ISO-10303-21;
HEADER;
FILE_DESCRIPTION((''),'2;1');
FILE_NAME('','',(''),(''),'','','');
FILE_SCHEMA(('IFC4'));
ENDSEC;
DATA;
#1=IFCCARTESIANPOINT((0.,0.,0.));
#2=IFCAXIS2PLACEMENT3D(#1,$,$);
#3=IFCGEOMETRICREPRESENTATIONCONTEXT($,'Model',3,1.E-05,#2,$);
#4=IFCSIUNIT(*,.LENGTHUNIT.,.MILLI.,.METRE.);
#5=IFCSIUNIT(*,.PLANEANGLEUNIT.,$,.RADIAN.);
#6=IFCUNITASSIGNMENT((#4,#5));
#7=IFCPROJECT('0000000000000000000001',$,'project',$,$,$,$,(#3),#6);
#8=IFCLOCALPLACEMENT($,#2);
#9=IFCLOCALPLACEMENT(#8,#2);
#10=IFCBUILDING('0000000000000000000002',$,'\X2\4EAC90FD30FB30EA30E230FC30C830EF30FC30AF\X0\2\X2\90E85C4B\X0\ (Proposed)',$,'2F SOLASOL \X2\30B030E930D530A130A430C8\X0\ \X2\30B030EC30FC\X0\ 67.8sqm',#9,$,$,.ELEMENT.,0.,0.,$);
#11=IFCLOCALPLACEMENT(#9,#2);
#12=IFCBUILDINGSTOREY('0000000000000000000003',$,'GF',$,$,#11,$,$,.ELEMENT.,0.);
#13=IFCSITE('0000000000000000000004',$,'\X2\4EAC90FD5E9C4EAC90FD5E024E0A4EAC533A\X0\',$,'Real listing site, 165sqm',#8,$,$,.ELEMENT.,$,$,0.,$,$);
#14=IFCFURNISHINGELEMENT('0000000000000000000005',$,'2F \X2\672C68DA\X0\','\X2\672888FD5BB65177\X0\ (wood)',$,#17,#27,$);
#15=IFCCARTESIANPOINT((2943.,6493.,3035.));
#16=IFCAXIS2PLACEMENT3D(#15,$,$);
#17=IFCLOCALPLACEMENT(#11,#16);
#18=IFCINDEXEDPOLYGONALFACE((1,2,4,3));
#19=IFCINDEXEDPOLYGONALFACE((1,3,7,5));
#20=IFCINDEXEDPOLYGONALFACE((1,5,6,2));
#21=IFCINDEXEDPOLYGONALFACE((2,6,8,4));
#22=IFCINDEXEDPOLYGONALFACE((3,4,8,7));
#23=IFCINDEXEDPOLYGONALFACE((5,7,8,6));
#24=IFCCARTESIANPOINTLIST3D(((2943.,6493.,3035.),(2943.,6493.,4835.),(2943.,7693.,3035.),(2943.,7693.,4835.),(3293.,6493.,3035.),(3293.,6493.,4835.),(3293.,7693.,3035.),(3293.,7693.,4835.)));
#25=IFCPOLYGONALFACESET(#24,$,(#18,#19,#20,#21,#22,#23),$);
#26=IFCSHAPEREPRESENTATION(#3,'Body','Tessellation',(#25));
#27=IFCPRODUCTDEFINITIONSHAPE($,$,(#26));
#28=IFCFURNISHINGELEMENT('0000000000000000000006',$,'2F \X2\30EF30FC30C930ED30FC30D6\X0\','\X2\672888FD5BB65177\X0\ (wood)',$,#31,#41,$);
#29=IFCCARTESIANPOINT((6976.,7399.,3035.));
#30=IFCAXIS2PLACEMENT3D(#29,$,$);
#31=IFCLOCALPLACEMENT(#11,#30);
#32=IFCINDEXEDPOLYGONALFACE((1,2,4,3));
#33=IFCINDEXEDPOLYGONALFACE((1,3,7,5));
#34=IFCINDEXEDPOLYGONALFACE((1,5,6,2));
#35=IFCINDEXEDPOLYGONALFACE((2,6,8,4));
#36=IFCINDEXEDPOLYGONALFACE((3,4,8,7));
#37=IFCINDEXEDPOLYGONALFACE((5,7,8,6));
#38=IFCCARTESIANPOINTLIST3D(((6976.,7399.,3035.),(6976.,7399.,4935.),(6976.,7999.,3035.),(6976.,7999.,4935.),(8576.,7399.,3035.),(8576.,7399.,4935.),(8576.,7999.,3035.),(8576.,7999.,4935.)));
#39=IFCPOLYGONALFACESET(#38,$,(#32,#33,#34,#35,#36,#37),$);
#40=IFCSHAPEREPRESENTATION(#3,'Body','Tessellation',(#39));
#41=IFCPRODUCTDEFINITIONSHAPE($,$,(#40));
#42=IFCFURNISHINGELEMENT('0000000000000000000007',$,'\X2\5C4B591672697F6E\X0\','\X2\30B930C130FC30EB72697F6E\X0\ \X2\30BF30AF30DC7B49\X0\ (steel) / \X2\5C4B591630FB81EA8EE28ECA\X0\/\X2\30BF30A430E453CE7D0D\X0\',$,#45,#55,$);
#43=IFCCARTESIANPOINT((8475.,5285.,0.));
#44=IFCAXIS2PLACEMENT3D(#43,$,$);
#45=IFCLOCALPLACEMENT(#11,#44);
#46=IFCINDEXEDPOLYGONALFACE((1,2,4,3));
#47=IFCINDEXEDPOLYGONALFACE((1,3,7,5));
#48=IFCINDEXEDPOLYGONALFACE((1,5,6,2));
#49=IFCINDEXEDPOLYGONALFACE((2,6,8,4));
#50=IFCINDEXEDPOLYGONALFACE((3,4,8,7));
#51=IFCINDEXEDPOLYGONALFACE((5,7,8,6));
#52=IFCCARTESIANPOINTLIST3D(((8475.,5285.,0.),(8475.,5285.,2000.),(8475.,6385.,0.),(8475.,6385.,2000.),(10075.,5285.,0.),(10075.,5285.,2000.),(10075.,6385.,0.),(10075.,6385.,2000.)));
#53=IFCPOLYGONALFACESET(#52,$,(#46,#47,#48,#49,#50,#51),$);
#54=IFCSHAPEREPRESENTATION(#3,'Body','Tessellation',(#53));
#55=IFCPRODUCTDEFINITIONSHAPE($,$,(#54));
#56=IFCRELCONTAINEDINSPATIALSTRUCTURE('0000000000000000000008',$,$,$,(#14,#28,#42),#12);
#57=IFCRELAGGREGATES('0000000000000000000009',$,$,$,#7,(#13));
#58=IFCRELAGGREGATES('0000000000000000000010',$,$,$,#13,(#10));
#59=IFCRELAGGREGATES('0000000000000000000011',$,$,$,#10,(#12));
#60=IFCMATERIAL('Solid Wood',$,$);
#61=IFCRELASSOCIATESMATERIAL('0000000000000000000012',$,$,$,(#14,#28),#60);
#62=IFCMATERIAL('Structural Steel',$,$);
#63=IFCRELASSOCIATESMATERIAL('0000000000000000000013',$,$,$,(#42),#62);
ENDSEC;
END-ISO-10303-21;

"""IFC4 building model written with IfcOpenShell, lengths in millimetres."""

from ifc_helpers import new_model, si_unit, frame, frame_2d, origin, place, context, project, spatial, rectangle, extrude, material, element, save


model = new_model("IFC4")

# Units and contexts
model_context = context("Model", 3, precision=1e-05, world=origin())
ifc_project = project(units=[si_unit("LENGTHUNIT", "METRE", prefix="MILLI"), si_unit("PLANEANGLEUNIT", "RADIAN")], contexts=[model_context])

# Site, building, storey
site_placement = place(None, origin())
site = spatial("IfcSite", under=ifc_project, at=site_placement, Name="京都府京都市上京区", ObjectType="Real listing site, 165sqm", CompositionType="ELEMENT", RefElevation=0.0)
building_placement = place(site_placement, origin())
building = spatial("IfcBuilding", under=site, at=building_placement, Name="京都・リモートワーク2部屋 (Proposed)", ObjectType="2F SOLASOL グラファイト グレー 67.8sqm", CompositionType="ELEMENT", ElevationOfRefHeight=0.0, ElevationOfTerrain=0.0)
storey_placement = place(building_placement, origin())
storey = spatial("IfcBuildingStorey", under=building, at=storey_placement, Name="GF", CompositionType="ELEMENT", Elevation=0.0)

# Shared definitions
ifc_material_1 = material(Name="Solid Wood")

# Shared definitions
ifc_material_2 = material(Name="Structural Steel")

# Furnishing elements
furnishing_1_placement = place(storey_placement, frame((2943.0, 6493.0, 3035.0)))
element("IfcFurnishingElement", 1, at=furnishing_1_placement, inside=storey, material=ifc_material_1, Name="2F 本棚", Description="木製家具 (wood)", context=model_context, shape_type="SweptSolid", body=[
    extrude(rectangle(XDim=350.0, YDim=1200.0, at=frame_2d((175.0, 600.0))), frame((2943.0, 6493.0, 3035.0)), (0.0, 0.0, 1.0), 1800.0),
])
furnishing_2_placement = place(storey_placement, frame((6976.0, 7399.0, 3035.0)))
element("IfcFurnishingElement", 2, at=furnishing_2_placement, inside=storey, material=ifc_material_1, Name="2F ワードローブ", Description="木製家具 (wood)", context=model_context, shape_type="SweptSolid", body=[
    extrude(rectangle(XDim=1600.0, YDim=600.0, at=frame_2d((800.0, 300.0))), frame((6976.0, 7399.0, 3035.0)), (0.0, 0.0, 1.0), 1900.0),
])
furnishing_3_placement = place(storey_placement, frame((8475.0, 5285.0, 0.0)))
element("IfcFurnishingElement", 3, at=furnishing_3_placement, inside=storey, material=ifc_material_2, Name="屋外物置", Description="スチール物置 タクボ等 (steel) / 屋外・自転車/タイヤ収納", context=model_context, shape_type="SweptSolid", body=[
    extrude(rectangle(XDim=1600.0, YDim=1100.0, at=frame_2d((800.0, 550.0))), frame((8475.0, 5285.0, 0.0)), (0.0, 0.0, 1.0), 2000.0),
])

save(model, "model.ifc")
